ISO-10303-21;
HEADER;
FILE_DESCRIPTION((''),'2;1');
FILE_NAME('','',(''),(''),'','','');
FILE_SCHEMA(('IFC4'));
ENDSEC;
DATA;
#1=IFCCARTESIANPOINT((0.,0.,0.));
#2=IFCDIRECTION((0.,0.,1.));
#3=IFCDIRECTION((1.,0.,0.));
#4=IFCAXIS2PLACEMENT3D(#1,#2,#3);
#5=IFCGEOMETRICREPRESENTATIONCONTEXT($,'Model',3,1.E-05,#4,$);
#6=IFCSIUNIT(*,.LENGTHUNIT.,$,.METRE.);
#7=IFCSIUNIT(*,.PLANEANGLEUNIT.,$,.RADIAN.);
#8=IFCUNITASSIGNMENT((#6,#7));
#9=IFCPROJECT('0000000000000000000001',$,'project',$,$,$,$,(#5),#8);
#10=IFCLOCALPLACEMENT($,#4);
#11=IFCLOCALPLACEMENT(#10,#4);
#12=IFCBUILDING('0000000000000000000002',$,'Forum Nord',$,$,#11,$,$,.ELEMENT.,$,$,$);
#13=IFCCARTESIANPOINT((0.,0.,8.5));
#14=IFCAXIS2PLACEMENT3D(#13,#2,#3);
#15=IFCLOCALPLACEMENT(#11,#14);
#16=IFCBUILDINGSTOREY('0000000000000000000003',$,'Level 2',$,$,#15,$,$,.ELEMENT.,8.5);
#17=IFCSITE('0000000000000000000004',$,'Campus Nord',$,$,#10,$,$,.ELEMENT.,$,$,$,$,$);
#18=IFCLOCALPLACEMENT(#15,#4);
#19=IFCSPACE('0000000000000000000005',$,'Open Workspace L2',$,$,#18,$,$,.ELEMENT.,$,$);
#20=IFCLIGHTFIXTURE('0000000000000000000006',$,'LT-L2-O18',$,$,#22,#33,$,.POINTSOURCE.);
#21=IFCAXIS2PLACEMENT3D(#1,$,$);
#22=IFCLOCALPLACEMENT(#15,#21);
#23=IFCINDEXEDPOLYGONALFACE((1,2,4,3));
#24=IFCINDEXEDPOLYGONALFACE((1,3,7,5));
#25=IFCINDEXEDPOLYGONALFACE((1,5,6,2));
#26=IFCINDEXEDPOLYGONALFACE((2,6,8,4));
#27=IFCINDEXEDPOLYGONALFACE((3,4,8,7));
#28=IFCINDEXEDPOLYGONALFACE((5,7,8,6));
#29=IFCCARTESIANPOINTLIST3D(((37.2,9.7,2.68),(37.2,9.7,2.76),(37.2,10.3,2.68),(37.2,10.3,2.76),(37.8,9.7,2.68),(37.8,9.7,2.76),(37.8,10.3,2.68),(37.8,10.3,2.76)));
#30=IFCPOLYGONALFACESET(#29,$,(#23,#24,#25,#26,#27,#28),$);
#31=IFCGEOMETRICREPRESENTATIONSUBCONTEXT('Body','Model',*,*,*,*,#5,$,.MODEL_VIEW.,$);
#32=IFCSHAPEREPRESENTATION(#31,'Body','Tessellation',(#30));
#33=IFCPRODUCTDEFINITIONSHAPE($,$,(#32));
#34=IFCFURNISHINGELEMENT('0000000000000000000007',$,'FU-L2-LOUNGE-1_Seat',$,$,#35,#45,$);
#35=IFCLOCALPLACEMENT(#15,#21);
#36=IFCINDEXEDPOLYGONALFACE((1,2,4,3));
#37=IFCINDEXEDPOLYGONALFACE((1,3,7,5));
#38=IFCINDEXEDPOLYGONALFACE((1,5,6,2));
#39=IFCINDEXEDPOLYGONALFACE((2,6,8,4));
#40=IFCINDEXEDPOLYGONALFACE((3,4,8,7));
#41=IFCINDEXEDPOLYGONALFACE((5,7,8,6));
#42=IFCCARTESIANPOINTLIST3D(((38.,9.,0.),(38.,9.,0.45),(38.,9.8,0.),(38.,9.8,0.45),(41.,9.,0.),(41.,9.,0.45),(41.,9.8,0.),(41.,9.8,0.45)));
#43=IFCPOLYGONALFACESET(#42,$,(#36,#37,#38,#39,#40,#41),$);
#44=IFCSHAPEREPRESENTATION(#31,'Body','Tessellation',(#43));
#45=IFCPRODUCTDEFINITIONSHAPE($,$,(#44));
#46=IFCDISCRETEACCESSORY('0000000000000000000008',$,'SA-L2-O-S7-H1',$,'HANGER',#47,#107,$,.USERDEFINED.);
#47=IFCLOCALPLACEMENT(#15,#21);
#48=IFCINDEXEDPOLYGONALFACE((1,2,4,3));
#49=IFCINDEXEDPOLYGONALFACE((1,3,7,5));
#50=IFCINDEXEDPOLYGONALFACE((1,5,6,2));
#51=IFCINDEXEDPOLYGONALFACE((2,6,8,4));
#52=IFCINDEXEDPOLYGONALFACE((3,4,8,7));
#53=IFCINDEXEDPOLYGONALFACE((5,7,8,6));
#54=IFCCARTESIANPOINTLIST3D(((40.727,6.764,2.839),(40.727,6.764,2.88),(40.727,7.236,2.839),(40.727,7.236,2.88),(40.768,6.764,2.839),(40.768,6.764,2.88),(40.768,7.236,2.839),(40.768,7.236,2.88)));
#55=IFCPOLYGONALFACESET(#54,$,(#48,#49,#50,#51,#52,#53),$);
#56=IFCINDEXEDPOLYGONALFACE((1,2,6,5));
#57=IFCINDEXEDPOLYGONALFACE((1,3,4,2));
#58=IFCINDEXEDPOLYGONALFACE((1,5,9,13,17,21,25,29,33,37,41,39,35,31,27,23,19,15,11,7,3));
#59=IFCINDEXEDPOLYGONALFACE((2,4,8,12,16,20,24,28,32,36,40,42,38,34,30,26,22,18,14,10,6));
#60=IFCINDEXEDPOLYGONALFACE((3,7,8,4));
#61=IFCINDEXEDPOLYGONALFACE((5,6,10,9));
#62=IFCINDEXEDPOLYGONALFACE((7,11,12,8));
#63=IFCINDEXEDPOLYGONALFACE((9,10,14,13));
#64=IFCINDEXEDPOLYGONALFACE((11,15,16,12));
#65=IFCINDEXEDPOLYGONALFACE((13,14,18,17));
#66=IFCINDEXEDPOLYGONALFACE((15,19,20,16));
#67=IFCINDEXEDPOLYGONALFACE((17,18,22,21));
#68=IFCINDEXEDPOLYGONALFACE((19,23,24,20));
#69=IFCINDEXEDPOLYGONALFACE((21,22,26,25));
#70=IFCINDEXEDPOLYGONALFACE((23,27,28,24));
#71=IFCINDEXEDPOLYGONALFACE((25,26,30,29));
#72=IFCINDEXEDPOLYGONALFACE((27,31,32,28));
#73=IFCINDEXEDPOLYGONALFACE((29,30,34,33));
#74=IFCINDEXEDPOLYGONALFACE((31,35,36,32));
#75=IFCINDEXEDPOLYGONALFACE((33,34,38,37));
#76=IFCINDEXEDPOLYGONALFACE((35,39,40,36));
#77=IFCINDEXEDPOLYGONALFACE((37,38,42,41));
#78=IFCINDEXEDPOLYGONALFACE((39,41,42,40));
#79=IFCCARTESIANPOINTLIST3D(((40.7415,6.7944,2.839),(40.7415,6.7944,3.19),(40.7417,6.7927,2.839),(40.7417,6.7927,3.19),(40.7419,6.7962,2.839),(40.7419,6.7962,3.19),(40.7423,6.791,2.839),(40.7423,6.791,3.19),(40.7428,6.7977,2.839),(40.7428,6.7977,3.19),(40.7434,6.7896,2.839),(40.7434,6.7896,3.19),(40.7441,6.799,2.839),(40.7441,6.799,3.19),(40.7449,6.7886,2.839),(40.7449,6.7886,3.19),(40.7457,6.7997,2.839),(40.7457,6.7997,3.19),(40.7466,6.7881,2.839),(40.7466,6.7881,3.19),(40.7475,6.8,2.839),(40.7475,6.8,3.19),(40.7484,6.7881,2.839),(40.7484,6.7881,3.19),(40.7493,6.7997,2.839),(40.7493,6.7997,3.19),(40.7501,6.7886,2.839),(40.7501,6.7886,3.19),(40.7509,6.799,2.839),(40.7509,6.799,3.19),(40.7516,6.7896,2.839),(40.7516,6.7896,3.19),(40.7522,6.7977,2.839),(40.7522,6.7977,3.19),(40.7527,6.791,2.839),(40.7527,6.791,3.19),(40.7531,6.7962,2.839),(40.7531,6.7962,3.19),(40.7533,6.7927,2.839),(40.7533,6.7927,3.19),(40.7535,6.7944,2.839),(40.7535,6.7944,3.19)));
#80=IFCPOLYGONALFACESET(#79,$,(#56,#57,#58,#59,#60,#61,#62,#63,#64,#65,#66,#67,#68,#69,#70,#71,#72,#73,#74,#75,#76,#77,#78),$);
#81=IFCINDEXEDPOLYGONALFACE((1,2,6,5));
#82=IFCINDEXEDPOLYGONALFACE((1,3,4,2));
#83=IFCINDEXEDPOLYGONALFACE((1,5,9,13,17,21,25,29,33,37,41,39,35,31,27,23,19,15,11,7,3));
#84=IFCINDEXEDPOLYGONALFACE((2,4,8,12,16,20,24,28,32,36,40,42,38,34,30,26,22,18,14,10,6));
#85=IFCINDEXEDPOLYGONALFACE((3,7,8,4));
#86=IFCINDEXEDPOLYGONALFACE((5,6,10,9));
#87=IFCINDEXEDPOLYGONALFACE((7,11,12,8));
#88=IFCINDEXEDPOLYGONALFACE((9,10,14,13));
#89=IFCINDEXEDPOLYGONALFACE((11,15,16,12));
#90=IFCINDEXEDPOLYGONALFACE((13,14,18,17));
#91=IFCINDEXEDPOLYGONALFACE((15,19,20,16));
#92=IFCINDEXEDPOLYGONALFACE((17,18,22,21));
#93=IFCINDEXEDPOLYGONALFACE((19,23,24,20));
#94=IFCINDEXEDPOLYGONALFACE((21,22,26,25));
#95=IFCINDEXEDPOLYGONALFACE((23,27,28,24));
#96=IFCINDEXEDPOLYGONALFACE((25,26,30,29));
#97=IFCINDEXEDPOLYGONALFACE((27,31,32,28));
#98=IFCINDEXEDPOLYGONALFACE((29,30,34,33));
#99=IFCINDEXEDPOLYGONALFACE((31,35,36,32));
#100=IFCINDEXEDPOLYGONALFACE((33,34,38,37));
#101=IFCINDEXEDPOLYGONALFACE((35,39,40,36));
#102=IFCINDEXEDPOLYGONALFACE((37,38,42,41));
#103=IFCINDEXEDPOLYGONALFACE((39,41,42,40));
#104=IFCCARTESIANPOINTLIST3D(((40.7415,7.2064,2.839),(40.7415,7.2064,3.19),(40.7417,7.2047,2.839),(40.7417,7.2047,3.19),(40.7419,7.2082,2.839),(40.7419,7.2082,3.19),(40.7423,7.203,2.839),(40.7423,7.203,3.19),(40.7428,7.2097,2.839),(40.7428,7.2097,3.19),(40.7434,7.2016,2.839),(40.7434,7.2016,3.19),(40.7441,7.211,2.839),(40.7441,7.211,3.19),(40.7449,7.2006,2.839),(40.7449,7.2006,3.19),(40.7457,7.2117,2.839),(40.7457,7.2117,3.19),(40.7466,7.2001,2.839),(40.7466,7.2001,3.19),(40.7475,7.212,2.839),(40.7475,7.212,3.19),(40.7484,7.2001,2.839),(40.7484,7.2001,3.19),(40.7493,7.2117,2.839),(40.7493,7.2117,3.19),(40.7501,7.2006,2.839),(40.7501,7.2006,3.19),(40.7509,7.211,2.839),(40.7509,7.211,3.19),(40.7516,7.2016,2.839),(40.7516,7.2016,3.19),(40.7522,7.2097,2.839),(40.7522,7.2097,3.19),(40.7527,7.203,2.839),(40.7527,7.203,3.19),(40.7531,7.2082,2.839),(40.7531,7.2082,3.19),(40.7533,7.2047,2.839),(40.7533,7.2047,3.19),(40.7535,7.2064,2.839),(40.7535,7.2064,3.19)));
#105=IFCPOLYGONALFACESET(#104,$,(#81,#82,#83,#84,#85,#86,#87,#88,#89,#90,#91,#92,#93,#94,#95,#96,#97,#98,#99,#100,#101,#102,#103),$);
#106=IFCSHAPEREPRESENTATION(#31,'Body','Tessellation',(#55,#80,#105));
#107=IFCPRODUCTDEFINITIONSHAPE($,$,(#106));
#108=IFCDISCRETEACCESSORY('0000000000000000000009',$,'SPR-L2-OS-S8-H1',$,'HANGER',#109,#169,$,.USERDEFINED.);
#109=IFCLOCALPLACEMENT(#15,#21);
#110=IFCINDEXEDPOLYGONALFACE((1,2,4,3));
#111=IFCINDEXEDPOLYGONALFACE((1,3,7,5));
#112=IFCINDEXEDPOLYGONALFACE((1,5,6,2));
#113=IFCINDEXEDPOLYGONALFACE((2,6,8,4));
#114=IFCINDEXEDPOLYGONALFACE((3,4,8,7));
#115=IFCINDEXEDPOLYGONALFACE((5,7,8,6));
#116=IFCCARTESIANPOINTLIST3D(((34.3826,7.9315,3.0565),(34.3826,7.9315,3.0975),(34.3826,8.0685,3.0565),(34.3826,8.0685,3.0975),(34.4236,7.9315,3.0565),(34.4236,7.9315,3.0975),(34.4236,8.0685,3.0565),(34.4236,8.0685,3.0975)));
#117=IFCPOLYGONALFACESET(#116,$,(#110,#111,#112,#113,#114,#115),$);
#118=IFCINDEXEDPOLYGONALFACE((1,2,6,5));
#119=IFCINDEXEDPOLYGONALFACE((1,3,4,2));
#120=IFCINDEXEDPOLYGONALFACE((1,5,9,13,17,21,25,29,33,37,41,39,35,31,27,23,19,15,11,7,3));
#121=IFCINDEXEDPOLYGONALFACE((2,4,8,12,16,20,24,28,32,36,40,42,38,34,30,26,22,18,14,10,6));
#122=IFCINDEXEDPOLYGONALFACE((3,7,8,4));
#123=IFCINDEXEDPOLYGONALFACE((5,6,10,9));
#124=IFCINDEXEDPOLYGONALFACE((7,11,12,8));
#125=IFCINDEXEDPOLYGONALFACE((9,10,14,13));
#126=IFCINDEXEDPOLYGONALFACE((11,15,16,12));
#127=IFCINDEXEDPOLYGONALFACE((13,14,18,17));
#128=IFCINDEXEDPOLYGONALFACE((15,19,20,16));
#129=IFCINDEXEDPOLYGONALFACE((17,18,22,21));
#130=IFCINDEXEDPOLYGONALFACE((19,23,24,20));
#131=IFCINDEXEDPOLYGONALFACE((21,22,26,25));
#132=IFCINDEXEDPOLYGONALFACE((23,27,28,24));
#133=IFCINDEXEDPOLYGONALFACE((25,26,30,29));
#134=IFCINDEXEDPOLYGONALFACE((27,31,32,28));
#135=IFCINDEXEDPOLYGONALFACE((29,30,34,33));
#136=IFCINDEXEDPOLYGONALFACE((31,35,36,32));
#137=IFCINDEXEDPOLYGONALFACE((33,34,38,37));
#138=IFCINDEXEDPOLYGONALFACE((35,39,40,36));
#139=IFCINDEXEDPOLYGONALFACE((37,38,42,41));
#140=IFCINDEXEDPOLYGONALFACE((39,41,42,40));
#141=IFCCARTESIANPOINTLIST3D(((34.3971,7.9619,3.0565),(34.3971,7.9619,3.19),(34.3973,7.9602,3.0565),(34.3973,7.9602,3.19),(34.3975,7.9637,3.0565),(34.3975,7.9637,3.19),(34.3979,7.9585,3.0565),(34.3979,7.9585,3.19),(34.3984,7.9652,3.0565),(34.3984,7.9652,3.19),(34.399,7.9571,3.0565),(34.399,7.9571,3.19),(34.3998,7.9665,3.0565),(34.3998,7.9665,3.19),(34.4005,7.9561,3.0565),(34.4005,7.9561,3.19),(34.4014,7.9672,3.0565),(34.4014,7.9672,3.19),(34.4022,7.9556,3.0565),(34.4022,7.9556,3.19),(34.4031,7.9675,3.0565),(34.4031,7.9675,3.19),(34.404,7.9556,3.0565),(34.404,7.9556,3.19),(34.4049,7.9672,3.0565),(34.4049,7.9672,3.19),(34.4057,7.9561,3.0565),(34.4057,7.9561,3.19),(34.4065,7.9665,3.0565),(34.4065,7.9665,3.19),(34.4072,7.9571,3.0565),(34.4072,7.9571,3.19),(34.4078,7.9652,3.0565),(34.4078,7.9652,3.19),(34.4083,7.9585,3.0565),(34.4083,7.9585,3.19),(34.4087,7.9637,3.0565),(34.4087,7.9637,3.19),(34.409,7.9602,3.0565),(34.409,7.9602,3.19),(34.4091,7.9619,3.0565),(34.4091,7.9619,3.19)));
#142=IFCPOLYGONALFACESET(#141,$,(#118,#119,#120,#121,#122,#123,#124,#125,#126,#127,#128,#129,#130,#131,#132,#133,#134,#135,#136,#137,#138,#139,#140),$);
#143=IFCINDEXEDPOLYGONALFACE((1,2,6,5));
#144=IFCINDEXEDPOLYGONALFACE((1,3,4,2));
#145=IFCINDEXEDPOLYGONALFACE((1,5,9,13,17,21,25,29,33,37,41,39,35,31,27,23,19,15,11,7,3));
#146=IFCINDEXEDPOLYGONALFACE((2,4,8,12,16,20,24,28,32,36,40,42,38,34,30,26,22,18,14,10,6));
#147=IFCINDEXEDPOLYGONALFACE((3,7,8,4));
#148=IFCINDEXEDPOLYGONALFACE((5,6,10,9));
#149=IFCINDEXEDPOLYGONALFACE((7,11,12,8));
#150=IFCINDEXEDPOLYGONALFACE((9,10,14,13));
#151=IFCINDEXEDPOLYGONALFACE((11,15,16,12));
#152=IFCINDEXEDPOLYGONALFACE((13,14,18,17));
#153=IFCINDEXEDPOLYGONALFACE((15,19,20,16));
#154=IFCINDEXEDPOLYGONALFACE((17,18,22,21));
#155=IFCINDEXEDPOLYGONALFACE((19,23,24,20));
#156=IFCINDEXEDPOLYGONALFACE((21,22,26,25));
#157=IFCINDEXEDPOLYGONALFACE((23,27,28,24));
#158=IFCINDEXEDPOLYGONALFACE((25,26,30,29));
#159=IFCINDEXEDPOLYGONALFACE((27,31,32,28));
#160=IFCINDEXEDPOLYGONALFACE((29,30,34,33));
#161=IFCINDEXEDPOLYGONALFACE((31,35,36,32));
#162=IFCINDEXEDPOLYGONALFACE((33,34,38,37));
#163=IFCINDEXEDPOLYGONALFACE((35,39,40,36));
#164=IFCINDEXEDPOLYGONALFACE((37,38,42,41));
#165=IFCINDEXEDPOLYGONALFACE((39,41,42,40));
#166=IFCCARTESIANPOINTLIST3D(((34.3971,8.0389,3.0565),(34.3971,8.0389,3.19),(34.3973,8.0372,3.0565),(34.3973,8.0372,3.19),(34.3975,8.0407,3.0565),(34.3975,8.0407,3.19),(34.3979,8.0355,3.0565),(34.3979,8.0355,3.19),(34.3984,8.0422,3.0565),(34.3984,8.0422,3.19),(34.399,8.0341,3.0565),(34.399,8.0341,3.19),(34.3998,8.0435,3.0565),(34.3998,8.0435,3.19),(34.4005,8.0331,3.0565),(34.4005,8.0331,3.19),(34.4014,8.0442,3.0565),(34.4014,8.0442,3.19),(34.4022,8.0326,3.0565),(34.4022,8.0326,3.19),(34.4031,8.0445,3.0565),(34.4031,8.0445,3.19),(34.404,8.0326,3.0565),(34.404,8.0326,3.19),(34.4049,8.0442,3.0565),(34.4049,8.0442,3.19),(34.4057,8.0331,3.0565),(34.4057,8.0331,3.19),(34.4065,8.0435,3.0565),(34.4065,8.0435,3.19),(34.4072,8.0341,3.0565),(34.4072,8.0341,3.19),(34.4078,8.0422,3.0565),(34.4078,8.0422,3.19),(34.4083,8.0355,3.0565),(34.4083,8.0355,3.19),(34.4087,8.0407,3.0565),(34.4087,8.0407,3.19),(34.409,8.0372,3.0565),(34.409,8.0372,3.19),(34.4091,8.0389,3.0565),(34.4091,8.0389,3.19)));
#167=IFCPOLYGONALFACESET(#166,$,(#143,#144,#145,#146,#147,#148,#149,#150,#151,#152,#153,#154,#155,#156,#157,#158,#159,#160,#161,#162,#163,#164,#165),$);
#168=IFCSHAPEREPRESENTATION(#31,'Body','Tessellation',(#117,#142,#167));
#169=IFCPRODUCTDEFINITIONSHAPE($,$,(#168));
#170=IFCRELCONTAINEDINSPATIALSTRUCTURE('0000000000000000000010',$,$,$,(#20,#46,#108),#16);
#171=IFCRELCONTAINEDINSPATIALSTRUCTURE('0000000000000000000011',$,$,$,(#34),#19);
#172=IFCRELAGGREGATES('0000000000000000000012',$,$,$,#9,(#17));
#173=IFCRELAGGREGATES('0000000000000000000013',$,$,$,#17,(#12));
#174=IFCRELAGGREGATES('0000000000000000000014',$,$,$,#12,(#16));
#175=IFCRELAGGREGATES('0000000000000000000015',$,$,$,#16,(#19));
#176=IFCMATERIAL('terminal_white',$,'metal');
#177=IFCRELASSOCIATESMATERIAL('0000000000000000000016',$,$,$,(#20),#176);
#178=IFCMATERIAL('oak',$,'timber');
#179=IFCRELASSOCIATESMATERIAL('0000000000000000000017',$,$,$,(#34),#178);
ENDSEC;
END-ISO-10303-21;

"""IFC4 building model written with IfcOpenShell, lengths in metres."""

from ifc_helpers import new_model, si_unit, frame, frame_2d, origin_with_axes, origin_2d_with_axis, place, context, subcontext, project, spatial, rectangle, circle, extrude, material, element, save


model = new_model("IFC4")

# Units and contexts
model_context = context("Model", 3, precision=1e-05, world=origin_with_axes())
body_context = subcontext(model_context, "Body", "Model", "MODEL_VIEW")
ifc_project = project(units=[si_unit("LENGTHUNIT", "METRE"), si_unit("PLANEANGLEUNIT", "RADIAN")], contexts=[model_context])

# Site, building, storey
site_placement = place(None, origin_with_axes())
site = spatial("IfcSite", under=ifc_project, at=site_placement, Name="Campus Nord", CompositionType="ELEMENT")
building_placement = place(site_placement, origin_with_axes())
building = spatial("IfcBuilding", under=site, at=building_placement, Name="Forum Nord", CompositionType="ELEMENT")
storey_placement = place(building_placement, frame((0.0, 0.0, 8.5), z_axis=(0.0, 0.0, 1.0), x_axis=(1.0, 0.0, 0.0)))
storey = spatial("IfcBuildingStorey", under=building, at=storey_placement, Name="Level 2", CompositionType="ELEMENT", Elevation=8.5)

# Light fixture
ifc_material_1 = material(Name="terminal_white", Category="metal")
light_fixture_placement = place(storey_placement, frame((37.5, 10.0, 2.68), z_axis=(0.0, 0.0, 1.0), x_axis=(1.0, 0.0, 0.0)))
element("IfcLightFixture", 1, at=light_fixture_placement, inside=storey, material=ifc_material_1, Name="LT-L2-O18", PredefinedType="POINTSOURCE", context=body_context, shape_type="SweptSolid", body=[
    extrude(rectangle(XDim=0.6, YDim=0.6, at=origin_2d_with_axis()), origin_with_axes(), (0.0, 0.0, 1.0), 0.08),
])

# Shared definitions
space_placement = place(storey_placement, origin_with_axes())
space = spatial("IfcSpace", under=storey, at=space_placement, Name="Open Workspace L2", CompositionType="ELEMENT")

# Furnishing element
ifc_material_2 = material(Name="oak", Category="timber")
furnishing_1_placement = place(storey_placement, frame((38.0, 9.0, 0.0), z_axis=(0.0, 0.0, 1.0), x_axis=(1.0, 0.0, 0.0)))
element("IfcFurnishingElement", 2, at=furnishing_1_placement, inside=space, material=ifc_material_2, Name="FU-L2-LOUNGE-1_Seat", context=body_context, shape_type="SweptSolid", body=[
    extrude(rectangle(XDim=3.0, YDim=0.8, at=frame_2d((1.5, 0.4), x_axis=(1.0, 0.0))), origin_with_axes(), (0.0, 0.0, 1.0), 0.45),
])

# Discrete accessories
discrete_accessory_1_placement = place(storey_placement, frame((40.7475, 7.0, 2.88), z_axis=(0.0, 0.0, 1.0), x_axis=(0.0, 1.0, 0.0)))
element("IfcDiscreteAccessory", 3, at=discrete_accessory_1_placement, inside=storey, Name="SA-L2-O-S7-H1", ObjectType="HANGER", PredefinedType="USERDEFINED", context=body_context, shape_type="SweptSolid", body=[
    extrude(rectangle(XDim=0.472, YDim=0.041, at=origin_2d_with_axis()), frame((0.0, 0.0, -0.041), z_axis=(0.0, 0.0, 1.0), x_axis=(1.0, 0.0, 0.0)), (0.0, 0.0, 1.0), 0.041),
    extrude(circle(Radius=0.006, at=frame_2d((-0.206, 0.0), x_axis=(1.0, 0.0))), frame((0.0, 0.0, -0.041), z_axis=(0.0, 0.0, 1.0), x_axis=(1.0, 0.0, 0.0)), (0.0, 0.0, 1.0), 0.351),
    extrude(circle(Radius=0.006, at=frame_2d((0.206, 0.0), x_axis=(1.0, 0.0))), frame((0.0, 0.0, -0.041), z_axis=(0.0, 0.0, 1.0), x_axis=(1.0, 0.0, 0.0)), (0.0, 0.0, 1.0), 0.351),
])
for number, where, z_axis, x_axis, name in (
    (4, (34.4031, 8.0, 3.0975), (0.0, 0.0, 1.0), (0.0, 1.0, 0.0), "SPR-L2-OS-S8-H1"),
):
    element("IfcDiscreteAccessory", number, at=place(storey_placement, frame(where, z_axis=z_axis, x_axis=x_axis)), inside=storey, Name=name, ObjectType="HANGER", PredefinedType="USERDEFINED", context=body_context, shape_type="SweptSolid", body=[
        extrude(rectangle(XDim=0.137, YDim=0.041, at=origin_2d_with_axis()), frame((0.0, 0.0, -0.041), z_axis=(0.0, 0.0, 1.0), x_axis=(1.0, 0.0, 0.0)), (0.0, 0.0, 1.0), 0.041),
        extrude(circle(Radius=0.006, at=frame_2d((-0.0385, 0.0), x_axis=(1.0, 0.0))), frame((0.0, 0.0, -0.041), z_axis=(0.0, 0.0, 1.0), x_axis=(1.0, 0.0, 0.0)), (0.0, 0.0, 1.0), 0.1335),
        extrude(circle(Radius=0.006, at=frame_2d((0.0385, 0.0), x_axis=(1.0, 0.0))), frame((0.0, 0.0, -0.041), z_axis=(0.0, 0.0, 1.0), x_axis=(1.0, 0.0, 0.0)), (0.0, 0.0, 1.0), 0.1335),
    ])

save(model, "model.ifc")
